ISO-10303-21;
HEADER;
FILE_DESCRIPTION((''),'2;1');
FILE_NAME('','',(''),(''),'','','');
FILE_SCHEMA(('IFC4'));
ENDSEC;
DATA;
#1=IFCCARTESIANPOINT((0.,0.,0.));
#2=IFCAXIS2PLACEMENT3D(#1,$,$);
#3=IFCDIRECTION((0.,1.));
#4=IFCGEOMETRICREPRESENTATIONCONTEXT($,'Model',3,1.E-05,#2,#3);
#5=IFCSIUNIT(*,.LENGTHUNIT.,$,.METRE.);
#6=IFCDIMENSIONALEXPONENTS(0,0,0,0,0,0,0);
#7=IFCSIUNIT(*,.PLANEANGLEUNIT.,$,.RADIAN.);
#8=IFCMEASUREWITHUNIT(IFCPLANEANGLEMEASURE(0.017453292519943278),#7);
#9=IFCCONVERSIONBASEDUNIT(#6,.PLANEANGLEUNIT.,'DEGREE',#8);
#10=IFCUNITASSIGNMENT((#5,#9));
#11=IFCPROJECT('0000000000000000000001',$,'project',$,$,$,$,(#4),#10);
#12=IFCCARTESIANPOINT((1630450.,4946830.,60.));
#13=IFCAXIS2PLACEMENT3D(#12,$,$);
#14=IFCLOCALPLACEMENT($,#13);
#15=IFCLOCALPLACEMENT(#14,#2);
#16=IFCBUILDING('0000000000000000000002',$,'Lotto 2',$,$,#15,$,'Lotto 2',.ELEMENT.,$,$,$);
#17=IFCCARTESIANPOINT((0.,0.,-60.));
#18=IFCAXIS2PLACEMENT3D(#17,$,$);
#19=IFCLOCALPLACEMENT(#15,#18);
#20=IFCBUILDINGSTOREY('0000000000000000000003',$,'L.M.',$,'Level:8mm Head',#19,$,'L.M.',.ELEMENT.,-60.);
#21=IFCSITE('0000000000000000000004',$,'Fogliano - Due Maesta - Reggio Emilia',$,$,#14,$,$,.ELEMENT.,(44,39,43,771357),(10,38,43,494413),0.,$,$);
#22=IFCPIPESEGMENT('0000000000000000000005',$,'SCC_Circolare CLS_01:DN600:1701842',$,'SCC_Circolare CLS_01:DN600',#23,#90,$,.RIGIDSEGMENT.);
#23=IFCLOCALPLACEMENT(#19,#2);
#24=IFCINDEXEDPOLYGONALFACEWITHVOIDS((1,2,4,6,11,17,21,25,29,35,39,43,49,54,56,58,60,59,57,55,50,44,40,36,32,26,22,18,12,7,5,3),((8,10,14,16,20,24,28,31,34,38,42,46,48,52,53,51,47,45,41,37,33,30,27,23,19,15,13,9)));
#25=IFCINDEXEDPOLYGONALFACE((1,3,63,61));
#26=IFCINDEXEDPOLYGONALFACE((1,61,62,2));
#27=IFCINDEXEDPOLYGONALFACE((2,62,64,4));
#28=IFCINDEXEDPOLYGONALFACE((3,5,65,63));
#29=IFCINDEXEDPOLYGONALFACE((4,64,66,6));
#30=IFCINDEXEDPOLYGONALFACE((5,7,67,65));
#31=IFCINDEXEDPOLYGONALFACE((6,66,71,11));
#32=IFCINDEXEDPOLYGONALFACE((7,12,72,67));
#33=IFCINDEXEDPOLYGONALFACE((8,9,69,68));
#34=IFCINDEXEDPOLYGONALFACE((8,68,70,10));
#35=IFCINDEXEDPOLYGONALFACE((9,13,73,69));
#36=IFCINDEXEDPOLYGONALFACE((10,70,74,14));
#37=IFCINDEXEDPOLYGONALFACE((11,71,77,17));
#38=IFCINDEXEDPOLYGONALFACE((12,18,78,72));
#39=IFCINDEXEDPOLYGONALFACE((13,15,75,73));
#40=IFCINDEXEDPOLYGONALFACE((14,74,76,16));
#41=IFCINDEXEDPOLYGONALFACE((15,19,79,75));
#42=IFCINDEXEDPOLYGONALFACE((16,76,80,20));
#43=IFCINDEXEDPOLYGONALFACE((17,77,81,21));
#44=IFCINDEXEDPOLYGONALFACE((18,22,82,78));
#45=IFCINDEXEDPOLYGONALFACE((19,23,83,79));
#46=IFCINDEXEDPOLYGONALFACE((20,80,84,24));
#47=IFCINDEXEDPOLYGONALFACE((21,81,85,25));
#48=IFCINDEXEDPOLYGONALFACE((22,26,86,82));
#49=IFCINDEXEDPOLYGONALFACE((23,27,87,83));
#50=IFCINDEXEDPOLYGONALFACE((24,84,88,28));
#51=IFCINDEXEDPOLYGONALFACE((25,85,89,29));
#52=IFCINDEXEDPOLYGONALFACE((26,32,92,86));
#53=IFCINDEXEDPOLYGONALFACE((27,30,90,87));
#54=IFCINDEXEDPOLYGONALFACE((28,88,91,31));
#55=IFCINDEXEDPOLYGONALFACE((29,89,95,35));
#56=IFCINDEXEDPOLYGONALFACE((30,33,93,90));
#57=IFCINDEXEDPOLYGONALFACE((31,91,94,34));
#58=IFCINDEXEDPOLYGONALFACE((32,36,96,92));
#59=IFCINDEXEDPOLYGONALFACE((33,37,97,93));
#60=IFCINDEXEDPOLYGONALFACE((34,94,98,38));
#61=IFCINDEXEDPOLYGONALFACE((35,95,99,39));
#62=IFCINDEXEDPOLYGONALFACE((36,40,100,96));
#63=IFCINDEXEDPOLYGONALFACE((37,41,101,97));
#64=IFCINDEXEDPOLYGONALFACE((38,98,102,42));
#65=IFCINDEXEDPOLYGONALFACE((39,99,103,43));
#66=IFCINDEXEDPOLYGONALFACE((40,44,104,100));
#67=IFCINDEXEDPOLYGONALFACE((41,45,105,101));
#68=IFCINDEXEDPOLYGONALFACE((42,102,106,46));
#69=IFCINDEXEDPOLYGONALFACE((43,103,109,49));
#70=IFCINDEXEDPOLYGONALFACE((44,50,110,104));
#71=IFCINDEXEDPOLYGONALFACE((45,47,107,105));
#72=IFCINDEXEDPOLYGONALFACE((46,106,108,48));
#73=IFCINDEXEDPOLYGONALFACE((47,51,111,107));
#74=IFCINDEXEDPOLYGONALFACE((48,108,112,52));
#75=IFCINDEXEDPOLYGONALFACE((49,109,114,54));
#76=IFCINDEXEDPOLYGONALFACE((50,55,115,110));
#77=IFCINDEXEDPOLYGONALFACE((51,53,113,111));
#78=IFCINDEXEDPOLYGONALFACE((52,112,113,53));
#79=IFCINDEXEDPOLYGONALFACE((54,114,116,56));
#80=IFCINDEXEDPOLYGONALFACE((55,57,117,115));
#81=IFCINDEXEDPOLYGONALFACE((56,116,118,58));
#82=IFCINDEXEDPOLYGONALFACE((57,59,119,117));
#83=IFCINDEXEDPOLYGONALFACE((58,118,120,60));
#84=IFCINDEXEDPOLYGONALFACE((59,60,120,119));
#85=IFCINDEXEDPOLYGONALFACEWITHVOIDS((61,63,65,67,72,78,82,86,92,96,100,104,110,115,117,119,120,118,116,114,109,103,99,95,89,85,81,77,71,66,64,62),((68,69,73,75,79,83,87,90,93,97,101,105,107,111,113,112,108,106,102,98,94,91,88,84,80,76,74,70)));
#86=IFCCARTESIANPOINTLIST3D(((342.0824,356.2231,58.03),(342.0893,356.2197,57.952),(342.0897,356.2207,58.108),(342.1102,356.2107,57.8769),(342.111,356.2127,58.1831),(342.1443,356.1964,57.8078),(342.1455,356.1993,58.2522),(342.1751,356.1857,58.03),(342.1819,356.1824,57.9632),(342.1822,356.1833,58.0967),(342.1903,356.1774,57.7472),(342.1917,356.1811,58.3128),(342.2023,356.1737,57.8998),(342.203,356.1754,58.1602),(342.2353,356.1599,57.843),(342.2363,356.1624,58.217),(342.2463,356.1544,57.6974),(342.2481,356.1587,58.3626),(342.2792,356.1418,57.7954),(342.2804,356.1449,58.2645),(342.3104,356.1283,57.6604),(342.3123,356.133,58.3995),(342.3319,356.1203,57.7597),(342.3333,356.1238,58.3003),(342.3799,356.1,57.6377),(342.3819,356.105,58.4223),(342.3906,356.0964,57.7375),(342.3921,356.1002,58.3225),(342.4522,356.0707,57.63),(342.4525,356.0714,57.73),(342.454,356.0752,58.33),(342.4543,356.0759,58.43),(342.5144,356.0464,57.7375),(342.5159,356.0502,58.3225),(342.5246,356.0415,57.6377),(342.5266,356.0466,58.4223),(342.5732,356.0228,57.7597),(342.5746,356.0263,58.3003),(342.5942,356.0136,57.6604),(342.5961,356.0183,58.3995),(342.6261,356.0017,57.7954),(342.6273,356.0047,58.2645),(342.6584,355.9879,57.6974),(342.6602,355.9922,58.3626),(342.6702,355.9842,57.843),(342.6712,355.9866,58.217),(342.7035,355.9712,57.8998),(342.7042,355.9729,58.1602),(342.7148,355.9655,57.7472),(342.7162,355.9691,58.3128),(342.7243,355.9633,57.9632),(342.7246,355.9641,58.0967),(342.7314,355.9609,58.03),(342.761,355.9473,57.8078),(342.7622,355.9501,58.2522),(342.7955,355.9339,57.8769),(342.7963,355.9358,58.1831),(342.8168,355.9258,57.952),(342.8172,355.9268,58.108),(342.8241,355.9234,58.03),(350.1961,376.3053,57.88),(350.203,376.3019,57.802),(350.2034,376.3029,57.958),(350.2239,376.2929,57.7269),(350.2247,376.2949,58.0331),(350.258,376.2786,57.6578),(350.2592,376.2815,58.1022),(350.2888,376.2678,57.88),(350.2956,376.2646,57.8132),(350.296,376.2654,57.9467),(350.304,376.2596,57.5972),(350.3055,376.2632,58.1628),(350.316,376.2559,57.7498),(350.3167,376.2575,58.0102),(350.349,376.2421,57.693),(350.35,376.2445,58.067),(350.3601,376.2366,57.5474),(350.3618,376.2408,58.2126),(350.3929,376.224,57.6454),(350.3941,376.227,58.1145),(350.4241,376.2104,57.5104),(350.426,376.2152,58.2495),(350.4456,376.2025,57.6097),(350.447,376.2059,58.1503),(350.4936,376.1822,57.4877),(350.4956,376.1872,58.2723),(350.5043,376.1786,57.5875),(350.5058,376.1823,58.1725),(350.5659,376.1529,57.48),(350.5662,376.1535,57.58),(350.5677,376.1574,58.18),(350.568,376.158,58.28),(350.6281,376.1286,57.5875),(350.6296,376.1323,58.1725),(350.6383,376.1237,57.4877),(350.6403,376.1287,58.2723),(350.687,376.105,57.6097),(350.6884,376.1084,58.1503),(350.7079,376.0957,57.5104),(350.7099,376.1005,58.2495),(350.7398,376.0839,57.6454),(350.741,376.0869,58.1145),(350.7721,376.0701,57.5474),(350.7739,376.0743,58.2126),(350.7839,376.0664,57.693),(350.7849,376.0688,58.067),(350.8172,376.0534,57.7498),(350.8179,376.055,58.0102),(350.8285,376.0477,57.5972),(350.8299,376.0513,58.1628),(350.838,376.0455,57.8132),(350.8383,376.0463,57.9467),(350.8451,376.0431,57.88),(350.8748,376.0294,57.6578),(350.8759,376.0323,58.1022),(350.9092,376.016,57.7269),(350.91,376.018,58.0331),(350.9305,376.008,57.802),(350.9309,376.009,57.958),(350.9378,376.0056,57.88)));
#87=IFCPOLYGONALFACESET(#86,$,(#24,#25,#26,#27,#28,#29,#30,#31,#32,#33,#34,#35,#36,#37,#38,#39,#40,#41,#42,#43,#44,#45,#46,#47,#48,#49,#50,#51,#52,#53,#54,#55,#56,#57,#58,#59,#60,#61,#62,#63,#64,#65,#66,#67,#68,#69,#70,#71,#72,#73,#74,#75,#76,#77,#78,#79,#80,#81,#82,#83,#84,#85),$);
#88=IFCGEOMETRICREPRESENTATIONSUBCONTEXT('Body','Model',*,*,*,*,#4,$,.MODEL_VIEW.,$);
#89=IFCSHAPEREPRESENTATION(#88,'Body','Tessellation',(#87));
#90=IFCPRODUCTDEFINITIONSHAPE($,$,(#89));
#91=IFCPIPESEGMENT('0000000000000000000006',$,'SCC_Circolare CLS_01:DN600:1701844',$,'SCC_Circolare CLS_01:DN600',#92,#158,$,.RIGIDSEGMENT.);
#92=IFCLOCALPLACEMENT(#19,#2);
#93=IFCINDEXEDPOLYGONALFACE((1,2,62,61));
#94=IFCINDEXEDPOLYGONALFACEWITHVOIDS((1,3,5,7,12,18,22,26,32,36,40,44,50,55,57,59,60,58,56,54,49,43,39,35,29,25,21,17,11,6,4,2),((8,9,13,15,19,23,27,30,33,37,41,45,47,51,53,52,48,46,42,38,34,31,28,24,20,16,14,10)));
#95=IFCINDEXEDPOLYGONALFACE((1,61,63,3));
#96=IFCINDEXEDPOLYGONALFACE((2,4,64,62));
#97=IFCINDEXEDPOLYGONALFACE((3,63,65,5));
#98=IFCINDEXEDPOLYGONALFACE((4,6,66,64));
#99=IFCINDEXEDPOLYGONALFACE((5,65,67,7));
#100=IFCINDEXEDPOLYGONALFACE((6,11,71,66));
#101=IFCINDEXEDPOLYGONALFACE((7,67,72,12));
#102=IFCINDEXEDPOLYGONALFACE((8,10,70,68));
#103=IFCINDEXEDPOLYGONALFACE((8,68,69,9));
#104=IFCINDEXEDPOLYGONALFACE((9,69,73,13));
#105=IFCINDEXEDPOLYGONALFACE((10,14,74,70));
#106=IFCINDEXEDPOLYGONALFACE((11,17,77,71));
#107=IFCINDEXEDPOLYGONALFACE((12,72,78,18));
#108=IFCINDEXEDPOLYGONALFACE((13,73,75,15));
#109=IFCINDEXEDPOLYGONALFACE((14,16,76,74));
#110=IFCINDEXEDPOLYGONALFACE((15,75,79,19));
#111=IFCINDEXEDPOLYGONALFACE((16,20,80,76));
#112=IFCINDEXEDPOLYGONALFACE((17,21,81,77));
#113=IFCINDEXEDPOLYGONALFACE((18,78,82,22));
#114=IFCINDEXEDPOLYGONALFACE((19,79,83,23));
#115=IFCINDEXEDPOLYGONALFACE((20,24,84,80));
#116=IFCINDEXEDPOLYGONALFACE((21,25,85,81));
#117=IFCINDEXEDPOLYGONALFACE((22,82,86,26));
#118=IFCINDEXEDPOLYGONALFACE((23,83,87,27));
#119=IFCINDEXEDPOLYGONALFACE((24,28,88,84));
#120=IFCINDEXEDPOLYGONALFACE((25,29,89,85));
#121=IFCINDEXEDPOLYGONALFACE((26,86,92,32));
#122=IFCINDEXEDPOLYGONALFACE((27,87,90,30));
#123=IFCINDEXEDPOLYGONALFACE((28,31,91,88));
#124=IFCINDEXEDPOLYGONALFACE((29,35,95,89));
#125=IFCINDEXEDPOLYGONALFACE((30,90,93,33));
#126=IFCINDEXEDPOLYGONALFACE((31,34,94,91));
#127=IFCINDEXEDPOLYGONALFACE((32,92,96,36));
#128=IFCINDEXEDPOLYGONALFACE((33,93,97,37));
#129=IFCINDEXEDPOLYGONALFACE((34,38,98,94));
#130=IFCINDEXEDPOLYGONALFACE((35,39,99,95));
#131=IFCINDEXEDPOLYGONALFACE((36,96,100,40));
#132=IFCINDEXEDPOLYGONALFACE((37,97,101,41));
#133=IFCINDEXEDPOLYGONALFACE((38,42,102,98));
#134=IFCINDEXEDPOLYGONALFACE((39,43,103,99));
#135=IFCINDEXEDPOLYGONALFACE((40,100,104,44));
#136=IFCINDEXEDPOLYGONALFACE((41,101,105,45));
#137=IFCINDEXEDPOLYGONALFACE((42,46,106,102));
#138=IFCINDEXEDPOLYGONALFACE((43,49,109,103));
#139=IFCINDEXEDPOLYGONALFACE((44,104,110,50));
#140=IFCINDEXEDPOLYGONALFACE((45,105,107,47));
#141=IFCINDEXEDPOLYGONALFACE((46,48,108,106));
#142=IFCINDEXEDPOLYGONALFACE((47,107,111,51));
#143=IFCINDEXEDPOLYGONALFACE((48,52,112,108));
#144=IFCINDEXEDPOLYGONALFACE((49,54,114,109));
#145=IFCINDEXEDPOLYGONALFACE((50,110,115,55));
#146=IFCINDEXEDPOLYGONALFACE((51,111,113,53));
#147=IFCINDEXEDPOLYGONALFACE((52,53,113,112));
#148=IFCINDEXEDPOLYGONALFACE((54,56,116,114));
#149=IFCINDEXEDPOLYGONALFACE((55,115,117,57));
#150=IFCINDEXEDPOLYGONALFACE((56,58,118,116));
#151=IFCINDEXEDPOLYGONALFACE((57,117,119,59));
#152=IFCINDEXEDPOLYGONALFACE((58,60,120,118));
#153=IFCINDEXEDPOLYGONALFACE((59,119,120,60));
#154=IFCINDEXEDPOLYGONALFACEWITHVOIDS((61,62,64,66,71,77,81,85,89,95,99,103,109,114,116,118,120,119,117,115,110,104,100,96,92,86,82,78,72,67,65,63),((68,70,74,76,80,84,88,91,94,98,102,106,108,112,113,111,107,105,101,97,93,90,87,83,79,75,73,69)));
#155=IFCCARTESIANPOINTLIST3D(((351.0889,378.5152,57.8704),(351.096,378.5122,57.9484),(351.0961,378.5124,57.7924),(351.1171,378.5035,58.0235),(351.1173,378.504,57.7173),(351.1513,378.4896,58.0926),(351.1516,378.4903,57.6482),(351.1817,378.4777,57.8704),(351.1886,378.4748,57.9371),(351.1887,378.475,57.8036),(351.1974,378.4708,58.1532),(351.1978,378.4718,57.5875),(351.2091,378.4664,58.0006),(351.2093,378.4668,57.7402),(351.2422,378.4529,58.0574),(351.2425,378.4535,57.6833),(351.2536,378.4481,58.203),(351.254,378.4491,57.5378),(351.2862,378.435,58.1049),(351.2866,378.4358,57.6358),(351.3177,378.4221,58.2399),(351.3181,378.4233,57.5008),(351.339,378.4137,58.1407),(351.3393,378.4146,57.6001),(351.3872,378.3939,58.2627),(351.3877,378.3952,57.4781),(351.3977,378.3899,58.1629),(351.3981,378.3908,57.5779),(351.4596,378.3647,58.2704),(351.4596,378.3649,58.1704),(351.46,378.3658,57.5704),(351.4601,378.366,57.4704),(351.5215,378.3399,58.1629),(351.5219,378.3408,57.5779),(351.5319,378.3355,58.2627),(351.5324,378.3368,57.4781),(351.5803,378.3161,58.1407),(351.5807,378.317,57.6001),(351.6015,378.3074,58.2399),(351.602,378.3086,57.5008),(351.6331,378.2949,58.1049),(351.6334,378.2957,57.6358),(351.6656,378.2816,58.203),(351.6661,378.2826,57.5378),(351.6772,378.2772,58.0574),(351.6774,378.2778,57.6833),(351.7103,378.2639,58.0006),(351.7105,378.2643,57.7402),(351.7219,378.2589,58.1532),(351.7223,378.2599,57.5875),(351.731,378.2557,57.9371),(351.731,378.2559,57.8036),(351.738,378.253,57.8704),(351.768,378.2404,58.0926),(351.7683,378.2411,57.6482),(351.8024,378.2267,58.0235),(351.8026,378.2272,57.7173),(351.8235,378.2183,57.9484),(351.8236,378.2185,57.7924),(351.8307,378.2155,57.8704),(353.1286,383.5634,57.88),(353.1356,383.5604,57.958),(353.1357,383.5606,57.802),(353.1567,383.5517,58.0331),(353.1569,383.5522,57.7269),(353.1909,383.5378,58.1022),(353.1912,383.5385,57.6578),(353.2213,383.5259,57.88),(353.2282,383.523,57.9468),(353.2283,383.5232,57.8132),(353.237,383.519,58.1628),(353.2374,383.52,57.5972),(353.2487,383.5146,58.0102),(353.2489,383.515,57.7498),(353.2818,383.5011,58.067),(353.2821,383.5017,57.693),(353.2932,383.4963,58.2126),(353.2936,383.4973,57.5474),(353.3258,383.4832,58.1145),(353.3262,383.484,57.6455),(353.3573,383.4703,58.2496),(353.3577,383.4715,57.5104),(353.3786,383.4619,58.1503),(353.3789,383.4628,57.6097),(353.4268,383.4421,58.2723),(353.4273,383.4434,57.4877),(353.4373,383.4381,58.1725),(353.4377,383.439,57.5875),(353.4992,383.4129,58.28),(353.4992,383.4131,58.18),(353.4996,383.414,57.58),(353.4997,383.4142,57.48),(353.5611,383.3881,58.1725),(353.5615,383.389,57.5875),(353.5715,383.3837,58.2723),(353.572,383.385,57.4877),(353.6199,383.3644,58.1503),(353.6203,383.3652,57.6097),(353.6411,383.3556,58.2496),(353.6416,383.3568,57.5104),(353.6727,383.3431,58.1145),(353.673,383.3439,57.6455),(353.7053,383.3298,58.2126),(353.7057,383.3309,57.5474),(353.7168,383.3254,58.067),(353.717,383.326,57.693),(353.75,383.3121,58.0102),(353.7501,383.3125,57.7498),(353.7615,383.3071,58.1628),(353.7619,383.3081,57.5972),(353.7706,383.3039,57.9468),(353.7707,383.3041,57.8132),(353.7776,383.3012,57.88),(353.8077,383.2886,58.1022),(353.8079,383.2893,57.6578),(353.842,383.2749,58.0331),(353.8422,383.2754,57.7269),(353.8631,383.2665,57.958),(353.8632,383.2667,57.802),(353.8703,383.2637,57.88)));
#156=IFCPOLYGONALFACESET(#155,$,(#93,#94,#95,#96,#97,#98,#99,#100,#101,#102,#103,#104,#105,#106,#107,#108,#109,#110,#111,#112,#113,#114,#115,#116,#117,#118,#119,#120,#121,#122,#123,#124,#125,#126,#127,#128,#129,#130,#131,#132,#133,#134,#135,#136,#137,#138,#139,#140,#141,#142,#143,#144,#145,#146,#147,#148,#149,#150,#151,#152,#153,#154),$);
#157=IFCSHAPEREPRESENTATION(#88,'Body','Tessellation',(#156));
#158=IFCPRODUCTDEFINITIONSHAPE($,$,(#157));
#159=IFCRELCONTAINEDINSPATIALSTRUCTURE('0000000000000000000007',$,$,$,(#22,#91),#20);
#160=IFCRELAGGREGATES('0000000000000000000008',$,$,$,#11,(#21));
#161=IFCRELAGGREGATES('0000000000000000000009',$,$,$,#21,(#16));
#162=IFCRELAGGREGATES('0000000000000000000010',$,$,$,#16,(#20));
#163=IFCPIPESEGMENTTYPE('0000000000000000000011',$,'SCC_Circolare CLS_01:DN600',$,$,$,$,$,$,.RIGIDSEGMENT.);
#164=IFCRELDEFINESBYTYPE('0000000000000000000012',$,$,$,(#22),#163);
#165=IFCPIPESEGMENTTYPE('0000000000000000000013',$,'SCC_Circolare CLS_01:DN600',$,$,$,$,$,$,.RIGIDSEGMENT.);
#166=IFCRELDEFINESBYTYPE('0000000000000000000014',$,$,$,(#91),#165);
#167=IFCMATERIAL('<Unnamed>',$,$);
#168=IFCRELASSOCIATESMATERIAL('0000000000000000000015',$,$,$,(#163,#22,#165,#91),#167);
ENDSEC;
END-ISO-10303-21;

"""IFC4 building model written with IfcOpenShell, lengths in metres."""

from ifc_helpers import new_model, entity, si_unit, converted_unit, direction, frame, origin, place, context, subcontext, project, spatial, arc, indexed_curve, outline, extrude, source, transform, mapped, material, type_object, type_shapes, element, save


model = new_model("IFC4")

# Units and contexts
model_context = context("Model", 3, precision=1e-05, world=origin(), true_north=direction((0.0, 1.0)))
body_context = subcontext(model_context, "Body", "Model", "MODEL_VIEW")
ifc_project = project(units=[si_unit("LENGTHUNIT", "METRE"), converted_unit("PLANEANGLEUNIT", "DEGREE", entity("IfcPlaneAngleMeasure", 0.017453292519943278), si_unit("PLANEANGLEUNIT", "RADIAN"), dimensions=[0, 0, 0, 0, 0, 0, 0])], contexts=[model_context])

# Site, building, storey
site_placement = place(None, frame((1630450.0, 4946830.0, 60.0)))
site = spatial("IfcSite", under=ifc_project, at=site_placement, Name="Fogliano - Due Maesta - Reggio Emilia", CompositionType="ELEMENT", RefLatitude=(44, 39, 43, 771357), RefLongitude=(10, 38, 43, 494413), RefElevation=0.0)
building_placement = place(site_placement, origin())
building = spatial("IfcBuilding", under=site, at=building_placement, Name="Lotto 2", LongName="Lotto 2", CompositionType="ELEMENT")
storey_placement = place(building_placement, frame((0.0, 0.0, -60.0)))
storey = spatial("IfcBuildingStorey", under=building, at=storey_placement, Name="L.M.", ObjectType="Level:8mm Head", LongName="L.M.", CompositionType="ELEMENT", Elevation=-60.0)

# Pipe segments
ifc_material_1 = material(Name="<Unnamed>")
pipe_segment_type_1 = type_object("IfcPipeSegmentType", Name="SCC_Circolare CLS_01:DN600", PredefinedType="RIGIDSEGMENT", material=ifc_material_1)
shared_shape_1 = source(origin(), body_context, "Body", "SweptSolid", [
    extrude(outline(indexed_curve([(0.0, -0.4), (0.4, 0.0), (0.0, 0.4), (-0.4, 0.0)], segments=[arc(1, 2, 3), arc(3, 4, 1)], self_intersect=False), holes=[indexed_curve([(0.0, -0.3), (-0.3, 0.0), (0.0, 0.3), (0.3, 0.0)], segments=[arc(1, 2, 3), arc(3, 4, 1)], self_intersect=False)]), frame((-10.8299, 0.0, 0.0), z_axis=(1.0, 0.0, 0.0), x_axis=(0.0, 0.0, -1.0)), (0.0, 0.0, 1.0), 21.6598),
])
type_shapes(pipe_segment_type_1, [shared_shape_1])
pipe_segment_1_placement = place(storey_placement, frame((346.5101, 366.1144, 57.955), z_axis=(0.002594, 0.006421, 0.999976), x_axis=(0.374598, 0.927162, -0.006925)))
element("IfcPipeSegment", 1, at=pipe_segment_1_placement, inside=storey, type_object=pipe_segment_type_1, material=ifc_material_1, Name="SCC_Circolare CLS_01:DN600:1701842", ObjectType="SCC_Circolare CLS_01:DN600", PredefinedType="RIGIDSEGMENT", context=body_context, shape_type="MappedRepresentation", body=[
    mapped(shared_shape_1, transform((0.0, 0.0, 0.0), scale=1.0)),
])
pipe_segment_type_2 = type_object("IfcPipeSegmentType", Name="SCC_Circolare CLS_01:DN600", PredefinedType="RIGIDSEGMENT", material=ifc_material_1)
shared_shape_2 = source(origin(), body_context, "Body", "SweptSolid", [
    extrude(outline(indexed_curve([(0.0, -0.4), (0.4, 0.0), (0.0, 0.4), (-0.4, 0.0)], segments=[arc(1, 2, 3), arc(3, 4, 1)], self_intersect=False), holes=[indexed_curve([(0.0, -0.3), (-0.3, 0.0), (0.0, 0.3), (0.3, 0.0)], segments=[arc(1, 2, 3), arc(3, 4, 1)], self_intersect=False)]), frame((-2.7223, 0.0, 0.0), z_axis=(1.0, 0.0, 0.0), x_axis=(0.0, 0.0, -1.0)), (0.0, 0.0, 1.0), 5.4447),
])
type_shapes(pipe_segment_type_2, [shared_shape_2])
pipe_segment_2_placement = place(storey_placement, frame((352.4796, 380.8895, 57.8752), z_axis=(-0.000661, -0.001637, 0.999998), x_axis=(0.374606, 0.927182, 0.001766)))
element("IfcPipeSegment", 2, at=pipe_segment_2_placement, inside=storey, type_object=pipe_segment_type_2, material=ifc_material_1, Name="SCC_Circolare CLS_01:DN600:1701844", ObjectType="SCC_Circolare CLS_01:DN600", PredefinedType="RIGIDSEGMENT", context=body_context, shape_type="MappedRepresentation", body=[
    mapped(shared_shape_2, transform((0.0, 0.0, 0.0), scale=1.0)),
])

save(model, "model.ifc")
